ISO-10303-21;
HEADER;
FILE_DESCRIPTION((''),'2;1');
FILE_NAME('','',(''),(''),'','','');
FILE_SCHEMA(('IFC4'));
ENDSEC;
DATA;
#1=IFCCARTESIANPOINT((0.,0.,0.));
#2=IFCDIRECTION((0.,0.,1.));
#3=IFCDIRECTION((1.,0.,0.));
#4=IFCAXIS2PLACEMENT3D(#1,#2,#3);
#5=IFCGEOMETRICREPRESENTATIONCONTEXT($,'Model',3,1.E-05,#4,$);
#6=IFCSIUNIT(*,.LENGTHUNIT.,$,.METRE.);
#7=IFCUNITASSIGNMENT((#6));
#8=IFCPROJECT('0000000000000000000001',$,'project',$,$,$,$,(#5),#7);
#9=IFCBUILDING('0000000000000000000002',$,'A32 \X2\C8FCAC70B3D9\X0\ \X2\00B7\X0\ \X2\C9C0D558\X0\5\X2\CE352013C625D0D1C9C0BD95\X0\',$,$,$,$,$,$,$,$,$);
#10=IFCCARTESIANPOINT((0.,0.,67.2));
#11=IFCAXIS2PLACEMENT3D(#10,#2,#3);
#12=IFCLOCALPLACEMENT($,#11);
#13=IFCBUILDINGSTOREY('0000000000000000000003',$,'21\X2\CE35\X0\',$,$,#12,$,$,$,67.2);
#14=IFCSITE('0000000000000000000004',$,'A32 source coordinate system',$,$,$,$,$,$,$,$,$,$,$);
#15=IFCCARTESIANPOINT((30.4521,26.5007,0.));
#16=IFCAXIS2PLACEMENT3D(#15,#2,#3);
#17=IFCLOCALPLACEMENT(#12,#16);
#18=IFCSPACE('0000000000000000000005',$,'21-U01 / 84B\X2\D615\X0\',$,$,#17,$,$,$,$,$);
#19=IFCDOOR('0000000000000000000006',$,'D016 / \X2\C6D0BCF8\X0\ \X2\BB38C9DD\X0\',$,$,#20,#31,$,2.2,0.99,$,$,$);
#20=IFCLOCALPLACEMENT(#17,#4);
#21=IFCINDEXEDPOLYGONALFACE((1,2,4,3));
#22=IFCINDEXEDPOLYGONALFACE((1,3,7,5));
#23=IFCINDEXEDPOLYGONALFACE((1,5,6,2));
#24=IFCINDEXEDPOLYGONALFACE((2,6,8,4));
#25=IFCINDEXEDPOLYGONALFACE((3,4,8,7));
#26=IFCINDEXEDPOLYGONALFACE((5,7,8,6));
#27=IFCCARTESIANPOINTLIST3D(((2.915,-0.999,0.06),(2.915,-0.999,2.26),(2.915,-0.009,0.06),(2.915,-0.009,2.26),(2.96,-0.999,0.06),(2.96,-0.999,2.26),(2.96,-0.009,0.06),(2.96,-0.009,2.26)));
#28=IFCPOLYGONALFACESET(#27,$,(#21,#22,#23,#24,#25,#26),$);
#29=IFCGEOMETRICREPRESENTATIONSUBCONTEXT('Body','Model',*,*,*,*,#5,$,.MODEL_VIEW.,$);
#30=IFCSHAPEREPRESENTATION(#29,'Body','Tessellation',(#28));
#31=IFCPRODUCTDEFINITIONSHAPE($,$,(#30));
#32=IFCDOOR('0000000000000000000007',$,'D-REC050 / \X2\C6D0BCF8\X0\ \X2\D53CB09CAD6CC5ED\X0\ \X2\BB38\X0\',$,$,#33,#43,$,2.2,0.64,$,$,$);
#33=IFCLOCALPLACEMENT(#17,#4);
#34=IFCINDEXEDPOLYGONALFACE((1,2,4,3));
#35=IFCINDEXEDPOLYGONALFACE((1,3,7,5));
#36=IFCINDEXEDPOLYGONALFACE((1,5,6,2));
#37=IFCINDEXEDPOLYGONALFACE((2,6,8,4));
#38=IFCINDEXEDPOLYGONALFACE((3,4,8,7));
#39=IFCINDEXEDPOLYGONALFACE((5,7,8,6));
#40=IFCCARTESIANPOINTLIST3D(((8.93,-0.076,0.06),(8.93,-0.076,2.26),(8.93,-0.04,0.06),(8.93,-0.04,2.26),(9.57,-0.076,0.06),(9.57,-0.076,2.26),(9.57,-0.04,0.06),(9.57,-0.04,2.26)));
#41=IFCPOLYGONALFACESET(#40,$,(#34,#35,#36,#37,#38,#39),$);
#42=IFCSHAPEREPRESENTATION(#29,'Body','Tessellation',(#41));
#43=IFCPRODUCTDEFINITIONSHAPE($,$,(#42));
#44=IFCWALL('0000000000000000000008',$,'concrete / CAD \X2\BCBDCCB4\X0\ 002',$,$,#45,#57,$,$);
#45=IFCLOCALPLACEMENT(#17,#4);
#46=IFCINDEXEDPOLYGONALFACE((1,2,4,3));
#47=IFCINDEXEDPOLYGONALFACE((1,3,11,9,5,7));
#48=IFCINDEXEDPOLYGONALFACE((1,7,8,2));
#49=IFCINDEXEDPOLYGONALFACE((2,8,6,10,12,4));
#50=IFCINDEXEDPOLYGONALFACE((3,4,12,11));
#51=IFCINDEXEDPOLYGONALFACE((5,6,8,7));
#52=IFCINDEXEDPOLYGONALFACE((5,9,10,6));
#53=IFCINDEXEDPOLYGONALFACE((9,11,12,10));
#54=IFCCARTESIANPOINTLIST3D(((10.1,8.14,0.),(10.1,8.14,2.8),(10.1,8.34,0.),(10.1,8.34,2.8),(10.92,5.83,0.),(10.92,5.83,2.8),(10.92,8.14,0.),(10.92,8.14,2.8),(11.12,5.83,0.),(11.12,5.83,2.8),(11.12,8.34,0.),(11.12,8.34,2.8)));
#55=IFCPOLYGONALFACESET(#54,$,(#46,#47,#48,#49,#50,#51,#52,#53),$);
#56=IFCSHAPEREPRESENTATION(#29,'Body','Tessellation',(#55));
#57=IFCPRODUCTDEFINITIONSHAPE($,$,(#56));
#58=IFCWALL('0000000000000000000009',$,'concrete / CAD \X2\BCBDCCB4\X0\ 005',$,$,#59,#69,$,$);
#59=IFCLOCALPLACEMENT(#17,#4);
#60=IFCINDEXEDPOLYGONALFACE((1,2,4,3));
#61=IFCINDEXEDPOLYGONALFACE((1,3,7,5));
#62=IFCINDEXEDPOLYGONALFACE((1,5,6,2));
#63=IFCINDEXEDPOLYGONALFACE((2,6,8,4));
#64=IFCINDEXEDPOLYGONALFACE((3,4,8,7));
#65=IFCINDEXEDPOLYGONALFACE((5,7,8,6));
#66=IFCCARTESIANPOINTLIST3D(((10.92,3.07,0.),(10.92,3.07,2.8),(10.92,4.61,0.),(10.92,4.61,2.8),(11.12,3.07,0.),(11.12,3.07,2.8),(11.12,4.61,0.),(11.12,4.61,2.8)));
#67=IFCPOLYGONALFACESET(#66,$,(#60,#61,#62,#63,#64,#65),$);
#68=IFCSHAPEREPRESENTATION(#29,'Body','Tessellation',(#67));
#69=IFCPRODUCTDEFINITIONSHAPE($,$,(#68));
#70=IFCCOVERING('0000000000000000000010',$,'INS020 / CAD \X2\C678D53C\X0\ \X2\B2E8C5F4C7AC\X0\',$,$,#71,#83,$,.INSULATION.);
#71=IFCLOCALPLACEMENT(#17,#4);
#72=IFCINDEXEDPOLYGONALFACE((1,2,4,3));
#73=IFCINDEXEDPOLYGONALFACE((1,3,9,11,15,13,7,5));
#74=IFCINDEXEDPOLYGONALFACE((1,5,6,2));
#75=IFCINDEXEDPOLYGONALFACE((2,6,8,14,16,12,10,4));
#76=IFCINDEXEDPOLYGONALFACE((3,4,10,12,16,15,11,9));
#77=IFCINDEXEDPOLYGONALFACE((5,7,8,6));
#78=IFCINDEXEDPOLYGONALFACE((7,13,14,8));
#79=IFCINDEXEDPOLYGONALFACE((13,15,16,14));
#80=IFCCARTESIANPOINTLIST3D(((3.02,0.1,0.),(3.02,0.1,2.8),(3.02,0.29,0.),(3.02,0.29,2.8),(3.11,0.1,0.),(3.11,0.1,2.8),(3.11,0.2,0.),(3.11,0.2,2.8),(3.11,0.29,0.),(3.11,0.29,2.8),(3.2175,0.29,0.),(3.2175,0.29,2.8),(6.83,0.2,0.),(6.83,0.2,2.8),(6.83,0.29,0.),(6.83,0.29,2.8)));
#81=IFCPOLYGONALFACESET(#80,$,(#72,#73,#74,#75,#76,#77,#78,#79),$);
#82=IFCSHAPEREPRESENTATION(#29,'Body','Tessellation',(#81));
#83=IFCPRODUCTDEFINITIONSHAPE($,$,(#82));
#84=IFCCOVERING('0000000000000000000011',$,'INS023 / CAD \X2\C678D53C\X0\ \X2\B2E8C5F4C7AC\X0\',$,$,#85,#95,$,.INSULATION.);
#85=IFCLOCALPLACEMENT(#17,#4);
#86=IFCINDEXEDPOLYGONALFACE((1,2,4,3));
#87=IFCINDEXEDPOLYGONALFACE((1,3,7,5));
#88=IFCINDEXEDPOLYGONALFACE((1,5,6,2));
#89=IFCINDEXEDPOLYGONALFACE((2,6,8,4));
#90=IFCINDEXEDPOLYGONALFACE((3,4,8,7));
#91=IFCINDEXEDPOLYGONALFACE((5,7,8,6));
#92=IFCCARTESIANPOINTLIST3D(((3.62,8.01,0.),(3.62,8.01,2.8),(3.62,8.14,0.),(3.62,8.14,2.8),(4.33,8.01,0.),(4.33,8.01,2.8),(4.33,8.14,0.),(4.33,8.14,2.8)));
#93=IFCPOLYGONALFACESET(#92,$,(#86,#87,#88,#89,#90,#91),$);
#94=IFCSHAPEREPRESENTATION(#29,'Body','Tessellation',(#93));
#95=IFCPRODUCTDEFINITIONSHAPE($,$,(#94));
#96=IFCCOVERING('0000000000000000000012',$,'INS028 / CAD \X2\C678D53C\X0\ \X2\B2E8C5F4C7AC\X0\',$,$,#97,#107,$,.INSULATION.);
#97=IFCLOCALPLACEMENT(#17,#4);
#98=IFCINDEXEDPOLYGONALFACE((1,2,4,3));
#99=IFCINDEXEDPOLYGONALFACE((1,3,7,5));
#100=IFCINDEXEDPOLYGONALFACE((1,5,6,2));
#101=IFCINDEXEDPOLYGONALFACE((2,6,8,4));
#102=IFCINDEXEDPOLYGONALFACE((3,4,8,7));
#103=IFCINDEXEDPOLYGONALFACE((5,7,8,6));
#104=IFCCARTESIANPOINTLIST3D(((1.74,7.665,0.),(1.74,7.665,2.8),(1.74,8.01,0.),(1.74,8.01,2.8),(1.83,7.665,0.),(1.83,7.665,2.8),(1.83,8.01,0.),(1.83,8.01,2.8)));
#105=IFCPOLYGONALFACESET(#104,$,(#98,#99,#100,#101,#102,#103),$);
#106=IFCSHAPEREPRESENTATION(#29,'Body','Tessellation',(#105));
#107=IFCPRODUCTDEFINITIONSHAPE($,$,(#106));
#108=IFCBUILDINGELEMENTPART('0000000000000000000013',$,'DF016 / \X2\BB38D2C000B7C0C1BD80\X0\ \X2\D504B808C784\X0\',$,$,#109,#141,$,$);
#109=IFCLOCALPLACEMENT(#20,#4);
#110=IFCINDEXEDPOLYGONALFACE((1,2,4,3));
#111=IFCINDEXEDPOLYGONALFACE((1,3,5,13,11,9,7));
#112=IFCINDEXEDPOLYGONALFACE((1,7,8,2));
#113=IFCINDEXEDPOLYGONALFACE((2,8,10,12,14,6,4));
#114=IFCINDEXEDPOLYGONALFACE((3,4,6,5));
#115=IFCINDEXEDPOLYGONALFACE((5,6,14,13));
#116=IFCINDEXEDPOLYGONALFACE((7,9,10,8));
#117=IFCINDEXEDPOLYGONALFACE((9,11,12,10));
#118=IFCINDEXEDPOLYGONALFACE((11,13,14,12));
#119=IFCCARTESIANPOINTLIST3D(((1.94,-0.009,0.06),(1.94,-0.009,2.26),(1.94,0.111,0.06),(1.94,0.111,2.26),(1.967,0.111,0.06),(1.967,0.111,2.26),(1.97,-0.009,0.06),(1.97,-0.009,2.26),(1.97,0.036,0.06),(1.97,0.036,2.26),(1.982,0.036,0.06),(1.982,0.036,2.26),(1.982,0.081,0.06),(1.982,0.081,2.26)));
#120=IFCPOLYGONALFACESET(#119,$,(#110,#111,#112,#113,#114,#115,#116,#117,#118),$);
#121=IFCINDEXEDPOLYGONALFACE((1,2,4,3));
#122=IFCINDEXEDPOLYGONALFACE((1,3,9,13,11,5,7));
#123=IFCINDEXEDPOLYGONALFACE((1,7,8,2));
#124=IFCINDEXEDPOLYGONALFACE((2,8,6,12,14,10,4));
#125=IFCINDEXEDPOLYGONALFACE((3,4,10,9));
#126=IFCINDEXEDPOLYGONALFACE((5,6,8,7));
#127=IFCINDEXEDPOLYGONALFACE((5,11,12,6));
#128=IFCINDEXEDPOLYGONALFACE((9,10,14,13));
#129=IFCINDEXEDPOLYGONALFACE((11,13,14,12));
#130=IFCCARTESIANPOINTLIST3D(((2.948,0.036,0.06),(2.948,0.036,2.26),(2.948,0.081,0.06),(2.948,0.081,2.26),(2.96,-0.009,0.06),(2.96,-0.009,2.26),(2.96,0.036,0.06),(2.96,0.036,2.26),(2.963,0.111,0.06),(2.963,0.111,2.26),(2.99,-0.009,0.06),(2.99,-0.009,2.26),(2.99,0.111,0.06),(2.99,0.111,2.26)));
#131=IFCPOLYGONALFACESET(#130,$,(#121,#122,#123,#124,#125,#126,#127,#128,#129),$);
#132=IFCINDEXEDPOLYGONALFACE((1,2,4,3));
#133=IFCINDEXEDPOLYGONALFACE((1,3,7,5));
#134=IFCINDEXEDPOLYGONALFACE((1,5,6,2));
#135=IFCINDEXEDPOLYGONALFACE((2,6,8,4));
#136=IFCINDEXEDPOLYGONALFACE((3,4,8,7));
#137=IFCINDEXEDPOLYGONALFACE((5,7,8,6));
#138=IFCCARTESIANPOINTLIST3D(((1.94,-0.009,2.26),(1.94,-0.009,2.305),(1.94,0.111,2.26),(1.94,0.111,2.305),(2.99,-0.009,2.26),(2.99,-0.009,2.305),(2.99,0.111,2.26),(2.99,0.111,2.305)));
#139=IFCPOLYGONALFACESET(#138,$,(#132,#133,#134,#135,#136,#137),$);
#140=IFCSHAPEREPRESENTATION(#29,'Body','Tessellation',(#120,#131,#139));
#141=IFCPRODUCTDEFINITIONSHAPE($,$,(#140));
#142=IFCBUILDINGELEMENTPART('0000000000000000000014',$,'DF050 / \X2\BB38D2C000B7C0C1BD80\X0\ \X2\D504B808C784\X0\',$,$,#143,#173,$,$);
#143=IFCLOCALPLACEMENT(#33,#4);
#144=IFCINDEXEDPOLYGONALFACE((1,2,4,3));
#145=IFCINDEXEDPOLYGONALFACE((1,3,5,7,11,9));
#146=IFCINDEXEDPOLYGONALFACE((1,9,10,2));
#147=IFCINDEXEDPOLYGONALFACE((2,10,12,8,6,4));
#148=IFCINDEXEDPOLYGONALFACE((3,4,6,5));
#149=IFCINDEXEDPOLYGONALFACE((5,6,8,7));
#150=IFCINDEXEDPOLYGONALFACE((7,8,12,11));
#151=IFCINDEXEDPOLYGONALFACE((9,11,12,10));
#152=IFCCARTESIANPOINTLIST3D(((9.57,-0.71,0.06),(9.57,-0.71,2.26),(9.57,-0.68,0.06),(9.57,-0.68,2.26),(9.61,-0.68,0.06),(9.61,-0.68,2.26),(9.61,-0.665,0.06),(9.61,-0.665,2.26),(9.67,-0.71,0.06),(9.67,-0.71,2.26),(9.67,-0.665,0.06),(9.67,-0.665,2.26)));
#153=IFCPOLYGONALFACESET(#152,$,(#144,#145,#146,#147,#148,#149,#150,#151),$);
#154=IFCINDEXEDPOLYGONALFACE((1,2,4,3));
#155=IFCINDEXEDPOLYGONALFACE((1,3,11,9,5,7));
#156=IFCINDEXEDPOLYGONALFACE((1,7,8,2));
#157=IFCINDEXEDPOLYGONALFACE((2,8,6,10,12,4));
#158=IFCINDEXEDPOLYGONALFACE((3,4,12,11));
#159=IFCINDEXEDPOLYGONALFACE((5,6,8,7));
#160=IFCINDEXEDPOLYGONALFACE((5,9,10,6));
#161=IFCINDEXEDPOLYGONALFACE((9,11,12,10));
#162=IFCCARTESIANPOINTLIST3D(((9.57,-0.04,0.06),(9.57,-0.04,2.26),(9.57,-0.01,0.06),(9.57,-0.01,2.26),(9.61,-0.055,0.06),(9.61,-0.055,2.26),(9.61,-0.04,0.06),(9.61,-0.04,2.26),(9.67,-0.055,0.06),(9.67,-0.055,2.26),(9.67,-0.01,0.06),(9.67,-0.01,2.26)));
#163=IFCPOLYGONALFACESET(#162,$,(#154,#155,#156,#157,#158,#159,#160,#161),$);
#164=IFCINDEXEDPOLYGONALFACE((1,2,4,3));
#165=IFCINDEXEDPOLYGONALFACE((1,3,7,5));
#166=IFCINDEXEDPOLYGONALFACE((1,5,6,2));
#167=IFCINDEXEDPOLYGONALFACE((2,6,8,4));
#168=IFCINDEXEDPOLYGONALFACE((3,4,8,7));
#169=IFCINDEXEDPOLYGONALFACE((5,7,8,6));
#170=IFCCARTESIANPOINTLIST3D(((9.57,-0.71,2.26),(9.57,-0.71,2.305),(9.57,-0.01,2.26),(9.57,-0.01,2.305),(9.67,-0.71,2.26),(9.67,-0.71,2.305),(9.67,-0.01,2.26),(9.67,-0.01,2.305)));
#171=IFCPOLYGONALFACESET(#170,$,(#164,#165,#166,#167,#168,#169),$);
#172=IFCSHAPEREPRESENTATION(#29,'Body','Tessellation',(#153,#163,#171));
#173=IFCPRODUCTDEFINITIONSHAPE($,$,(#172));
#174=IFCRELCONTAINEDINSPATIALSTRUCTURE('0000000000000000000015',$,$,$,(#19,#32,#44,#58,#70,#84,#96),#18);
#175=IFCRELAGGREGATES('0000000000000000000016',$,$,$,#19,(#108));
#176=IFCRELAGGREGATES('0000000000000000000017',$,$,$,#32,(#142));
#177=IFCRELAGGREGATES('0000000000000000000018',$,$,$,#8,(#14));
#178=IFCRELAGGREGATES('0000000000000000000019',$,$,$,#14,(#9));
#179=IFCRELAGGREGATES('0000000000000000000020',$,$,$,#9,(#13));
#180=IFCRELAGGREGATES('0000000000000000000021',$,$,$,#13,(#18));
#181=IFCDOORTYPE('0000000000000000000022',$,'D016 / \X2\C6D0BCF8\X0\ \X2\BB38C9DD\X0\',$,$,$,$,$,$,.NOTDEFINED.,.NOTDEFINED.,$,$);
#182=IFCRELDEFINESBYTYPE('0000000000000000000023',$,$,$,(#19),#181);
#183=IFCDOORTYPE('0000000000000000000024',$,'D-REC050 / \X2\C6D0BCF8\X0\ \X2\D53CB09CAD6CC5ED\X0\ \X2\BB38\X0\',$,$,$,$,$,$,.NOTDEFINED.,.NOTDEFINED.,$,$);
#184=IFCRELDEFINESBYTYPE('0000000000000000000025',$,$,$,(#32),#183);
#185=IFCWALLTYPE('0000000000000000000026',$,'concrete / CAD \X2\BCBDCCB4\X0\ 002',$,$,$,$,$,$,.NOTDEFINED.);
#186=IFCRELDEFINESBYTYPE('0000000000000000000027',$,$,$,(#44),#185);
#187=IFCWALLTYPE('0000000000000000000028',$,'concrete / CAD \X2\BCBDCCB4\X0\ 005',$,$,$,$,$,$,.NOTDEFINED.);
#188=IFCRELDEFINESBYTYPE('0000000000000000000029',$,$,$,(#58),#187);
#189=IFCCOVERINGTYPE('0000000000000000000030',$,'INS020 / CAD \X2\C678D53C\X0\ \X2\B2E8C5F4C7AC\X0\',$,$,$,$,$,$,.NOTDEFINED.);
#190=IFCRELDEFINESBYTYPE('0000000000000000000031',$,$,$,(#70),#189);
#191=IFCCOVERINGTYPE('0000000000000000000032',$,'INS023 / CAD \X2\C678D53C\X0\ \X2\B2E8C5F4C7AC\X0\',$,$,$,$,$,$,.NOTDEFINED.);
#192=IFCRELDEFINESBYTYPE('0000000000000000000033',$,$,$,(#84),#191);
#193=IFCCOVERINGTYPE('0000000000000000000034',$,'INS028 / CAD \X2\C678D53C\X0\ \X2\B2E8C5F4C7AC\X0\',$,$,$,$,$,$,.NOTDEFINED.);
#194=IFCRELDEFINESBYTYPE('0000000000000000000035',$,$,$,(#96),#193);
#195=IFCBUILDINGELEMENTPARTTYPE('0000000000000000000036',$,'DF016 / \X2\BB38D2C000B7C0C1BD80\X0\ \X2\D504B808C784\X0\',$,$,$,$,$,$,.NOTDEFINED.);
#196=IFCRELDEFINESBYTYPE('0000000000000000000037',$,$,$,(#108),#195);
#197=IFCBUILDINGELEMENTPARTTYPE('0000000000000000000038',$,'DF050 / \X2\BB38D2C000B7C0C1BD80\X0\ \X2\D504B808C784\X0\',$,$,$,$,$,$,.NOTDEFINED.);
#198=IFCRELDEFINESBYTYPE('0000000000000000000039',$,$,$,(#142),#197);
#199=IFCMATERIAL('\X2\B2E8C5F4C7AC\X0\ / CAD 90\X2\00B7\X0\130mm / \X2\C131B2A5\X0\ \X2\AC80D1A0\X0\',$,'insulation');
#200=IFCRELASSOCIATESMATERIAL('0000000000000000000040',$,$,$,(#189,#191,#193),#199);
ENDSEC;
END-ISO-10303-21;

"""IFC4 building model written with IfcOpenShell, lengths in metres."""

from ifc_helpers import new_model, si_unit, frame, origin, origin_with_axes, place, context, subcontext, project, spatial, polyline, outline, extrude, source, transform, mapped, material, type_object, type_shapes, element, aggregate, save


model = new_model("IFC4")

# Units and contexts
model_context = context("Model", 3, precision=1e-05, world=origin_with_axes())
body_context = subcontext(model_context, "Body", "Model", "MODEL_VIEW")
ifc_project = project(units=[si_unit("LENGTHUNIT", "METRE")], contexts=[model_context])

# Site, building, storey, space
storey_placement = place(None, frame((0.0, 0.0, 67.2), z_axis=(0.0, 0.0, 1.0), x_axis=(1.0, 0.0, 0.0)))
space_placement = place(storey_placement, frame((30.4521, 26.5007, 0.0), z_axis=(0.0, 0.0, 1.0), x_axis=(1.0, 0.0, 0.0)))
site = spatial("IfcSite", under=ifc_project, Name="A32 source coordinate system")
building = spatial("IfcBuilding", under=site, Name="A32 주거동 · 지하5층–옥탑지붕")
storey = spatial("IfcBuildingStorey", under=building, at=storey_placement, Name="21층", Elevation=67.2)
space = spatial("IfcSpace", under=storey, at=space_placement, Name="21-U01 / 84B형")

# Doors
door_type_1 = type_object("IfcDoorType", Name="D016 / 원본 문짝", OperationType="NOTDEFINED", PredefinedType="NOTDEFINED")
shared_shape_1 = source(origin(), body_context, "Body", "SweptSolid", [
    extrude(outline(polyline([(2.96, -0.009), (2.96, -0.999), (2.915, -0.999), (2.915, -0.009), (2.96, -0.009)])), frame((0.0, 0.0, 0.06)), (0.0, 0.0, 1.0), 2.2),
])
type_shapes(door_type_1, [shared_shape_1])
door_1_placement = place(space_placement, origin_with_axes())
door_1 = element("IfcDoor", 1, at=door_1_placement, inside=space, type_object=door_type_1, Name="D016 / 원본 문짝", OverallHeight=2.2, OverallWidth=0.99, context=body_context, shape_type="MappedRepresentation", body=[
    mapped(shared_shape_1, transform((0.0, 0.0, 0.0), scale=1.0)),
])
door_type_2 = type_object("IfcDoorType", Name="D-REC050 / 원본 피난구역 문", OperationType="NOTDEFINED", PredefinedType="NOTDEFINED")
shared_shape_2 = source(origin(), body_context, "Body", "SweptSolid", [
    extrude(outline(polyline([(9.57, -0.04), (9.57, -0.076), (8.93, -0.076), (8.93, -0.04), (9.57, -0.04)])), frame((0.0, 0.0, 0.06)), (0.0, 0.0, 1.0), 2.2),
])
type_shapes(door_type_2, [shared_shape_2])
door_2_placement = place(space_placement, origin_with_axes())
door_2 = element("IfcDoor", 2, at=door_2_placement, inside=space, type_object=door_type_2, Name="D-REC050 / 원본 피난구역 문", OverallHeight=2.2, OverallWidth=0.64, context=body_context, shape_type="MappedRepresentation", body=[
    mapped(shared_shape_2, transform((0.0, 0.0, 0.0), scale=1.0)),
])

# Walls
wall_type_1 = type_object("IfcWallType", Name="concrete / CAD 벽체 002", PredefinedType="NOTDEFINED")
shared_shape_3 = source(origin(), body_context, "Body", "SweptSolid", [
    extrude(outline(polyline([(11.12, 5.83), (10.92, 5.83), (10.92, 8.14), (10.1, 8.14), (10.1, 8.34), (11.12, 8.34), (11.12, 5.83)])), origin(), (0.0, 0.0, 1.0), 2.8),
])
type_shapes(wall_type_1, [shared_shape_3])
wall_1_placement = place(space_placement, origin_with_axes())
element("IfcWall", 3, at=wall_1_placement, inside=space, type_object=wall_type_1, Name="concrete / CAD 벽체 002", context=body_context, shape_type="MappedRepresentation", body=[
    mapped(shared_shape_3, transform((0.0, 0.0, 0.0), scale=1.0)),
])
wall_type_2 = type_object("IfcWallType", Name="concrete / CAD 벽체 005", PredefinedType="NOTDEFINED")
shared_shape_4 = source(origin(), body_context, "Body", "SweptSolid", [
    extrude(outline(polyline([(11.12, 3.07), (10.92, 3.07), (10.92, 4.61), (11.12, 4.61), (11.12, 3.07)])), origin(), (0.0, 0.0, 1.0), 2.8),
])
type_shapes(wall_type_2, [shared_shape_4])
wall_2_placement = place(space_placement, origin_with_axes())
element("IfcWall", 4, at=wall_2_placement, inside=space, type_object=wall_type_2, Name="concrete / CAD 벽체 005", context=body_context, shape_type="MappedRepresentation", body=[
    mapped(shared_shape_4, transform((0.0, 0.0, 0.0), scale=1.0)),
])

# Coverings
ifc_material = material(Name="단열재 / CAD 90·130mm / 성능 검토", Category="insulation")
covering_type_1 = type_object("IfcCoveringType", Name="INS020 / CAD 외피 단열재", PredefinedType="NOTDEFINED", material=ifc_material)
shared_shape_5 = source(origin(), body_context, "Body", "SweptSolid", [
    extrude(outline(polyline([(3.11, 0.2), (3.11, 0.1), (3.02, 0.1), (3.02, 0.29), (3.11, 0.29), (3.2175, 0.29), (6.83, 0.29), (6.83, 0.2), (3.11, 0.2)])), origin(), (0.0, 0.0, 1.0), 2.8),
])
type_shapes(covering_type_1, [shared_shape_5])
covering_1_placement = place(space_placement, origin_with_axes())
element("IfcCovering", 5, at=covering_1_placement, inside=space, type_object=covering_type_1, Name="INS020 / CAD 외피 단열재", PredefinedType="INSULATION", context=body_context, shape_type="MappedRepresentation", body=[
    mapped(shared_shape_5, transform((0.0, 0.0, 0.0), scale=1.0)),
])
covering_type_2 = type_object("IfcCoveringType", Name="INS023 / CAD 외피 단열재", PredefinedType="NOTDEFINED", material=ifc_material)
shared_shape_6 = source(origin(), body_context, "Body", "SweptSolid", [
    extrude(outline(polyline([(4.33, 8.01), (3.62, 8.01), (3.62, 8.14), (4.33, 8.14), (4.33, 8.01)])), origin(), (0.0, 0.0, 1.0), 2.8),
])
type_shapes(covering_type_2, [shared_shape_6])
covering_2_placement = place(space_placement, origin_with_axes())
element("IfcCovering", 6, at=covering_2_placement, inside=space, type_object=covering_type_2, Name="INS023 / CAD 외피 단열재", PredefinedType="INSULATION", context=body_context, shape_type="MappedRepresentation", body=[
    mapped(shared_shape_6, transform((0.0, 0.0, 0.0), scale=1.0)),
])
covering_type_3 = type_object("IfcCoveringType", Name="INS028 / CAD 외피 단열재", PredefinedType="NOTDEFINED", material=ifc_material)
shared_shape_7 = source(origin(), body_context, "Body", "SweptSolid", [
    extrude(outline(polyline([(1.74, 8.01), (1.83, 8.01), (1.83, 7.665), (1.74, 7.665), (1.74, 8.01)])), origin(), (0.0, 0.0, 1.0), 2.8),
])
type_shapes(covering_type_3, [shared_shape_7])
covering_3_placement = place(space_placement, origin_with_axes())
element("IfcCovering", 7, at=covering_3_placement, inside=space, type_object=covering_type_3, Name="INS028 / CAD 외피 단열재", PredefinedType="INSULATION", context=body_context, shape_type="MappedRepresentation", body=[
    mapped(shared_shape_7, transform((0.0, 0.0, 0.0), scale=1.0)),
])

# Building element parts
building_element_part_type_1 = type_object("IfcBuildingElementPartType", Name="DF016 / 문틀·상부 프레임", PredefinedType="NOTDEFINED")
shared_shape_8 = source(origin(), body_context, "Body", "SweptSolid", [
    extrude(outline(polyline([(1.94, 0.111), (1.967, 0.111), (1.982, 0.081), (1.982, 0.036), (1.97, 0.036), (1.97, -0.009), (1.94, -0.009), (1.94, 0.111)])), frame((0.0, 0.0, 0.06)), (0.0, 0.0, 1.0), 2.2),
    extrude(outline(polyline([(2.96, -0.009), (2.96, 0.036), (2.948, 0.036), (2.948, 0.081), (2.963, 0.111), (2.99, 0.111), (2.99, -0.009), (2.96, -0.009)])), frame((0.0, 0.0, 0.06)), (0.0, 0.0, 1.0), 2.2),
    extrude(outline(polyline([(1.94, -0.009), (1.94, 0.111), (2.99, 0.111), (2.99, -0.009), (1.94, -0.009)])), frame((0.0, 0.0, 2.26)), (0.0, 0.0, 1.0), 0.045),
])
type_shapes(building_element_part_type_1, [shared_shape_8])
building_element_part_1_placement = place(door_1_placement, origin_with_axes())
building_element_part_1 = element("IfcBuildingElementPart", 8, at=building_element_part_1_placement, type_object=building_element_part_type_1, Name="DF016 / 문틀·상부 프레임", context=body_context, shape_type="MappedRepresentation", body=[
    mapped(shared_shape_8, transform((0.0, 0.0, 0.0), scale=1.0)),
])
aggregate(door_1, [building_element_part_1])
building_element_part_type_2 = type_object("IfcBuildingElementPartType", Name="DF050 / 문틀·상부 프레임", PredefinedType="NOTDEFINED")
shared_shape_9 = source(origin(), body_context, "Body", "SweptSolid", [
    extrude(outline(polyline([(9.57, -0.68), (9.61, -0.68), (9.61, -0.665), (9.67, -0.665), (9.67, -0.71), (9.57, -0.71), (9.57, -0.68)])), frame((0.0, 0.0, 0.06)), (0.0, 0.0, 1.0), 2.2),
    extrude(outline(polyline([(9.67, -0.01), (9.67, -0.055), (9.61, -0.055), (9.61, -0.04), (9.57, -0.04), (9.57, -0.01), (9.67, -0.01)])), frame((0.0, 0.0, 0.06)), (0.0, 0.0, 1.0), 2.2),
    extrude(outline(polyline([(9.57, -0.71), (9.57, -0.01), (9.67, -0.01), (9.67, -0.71), (9.57, -0.71)])), frame((0.0, 0.0, 2.26)), (0.0, 0.0, 1.0), 0.045),
])
type_shapes(building_element_part_type_2, [shared_shape_9])
building_element_part_2_placement = place(door_2_placement, origin_with_axes())
building_element_part_2 = element("IfcBuildingElementPart", 9, at=building_element_part_2_placement, type_object=building_element_part_type_2, Name="DF050 / 문틀·상부 프레임", context=body_context, shape_type="MappedRepresentation", body=[
    mapped(shared_shape_9, transform((0.0, 0.0, 0.0), scale=1.0)),
])
aggregate(door_2, [building_element_part_2])

save(model, "model.ifc")
